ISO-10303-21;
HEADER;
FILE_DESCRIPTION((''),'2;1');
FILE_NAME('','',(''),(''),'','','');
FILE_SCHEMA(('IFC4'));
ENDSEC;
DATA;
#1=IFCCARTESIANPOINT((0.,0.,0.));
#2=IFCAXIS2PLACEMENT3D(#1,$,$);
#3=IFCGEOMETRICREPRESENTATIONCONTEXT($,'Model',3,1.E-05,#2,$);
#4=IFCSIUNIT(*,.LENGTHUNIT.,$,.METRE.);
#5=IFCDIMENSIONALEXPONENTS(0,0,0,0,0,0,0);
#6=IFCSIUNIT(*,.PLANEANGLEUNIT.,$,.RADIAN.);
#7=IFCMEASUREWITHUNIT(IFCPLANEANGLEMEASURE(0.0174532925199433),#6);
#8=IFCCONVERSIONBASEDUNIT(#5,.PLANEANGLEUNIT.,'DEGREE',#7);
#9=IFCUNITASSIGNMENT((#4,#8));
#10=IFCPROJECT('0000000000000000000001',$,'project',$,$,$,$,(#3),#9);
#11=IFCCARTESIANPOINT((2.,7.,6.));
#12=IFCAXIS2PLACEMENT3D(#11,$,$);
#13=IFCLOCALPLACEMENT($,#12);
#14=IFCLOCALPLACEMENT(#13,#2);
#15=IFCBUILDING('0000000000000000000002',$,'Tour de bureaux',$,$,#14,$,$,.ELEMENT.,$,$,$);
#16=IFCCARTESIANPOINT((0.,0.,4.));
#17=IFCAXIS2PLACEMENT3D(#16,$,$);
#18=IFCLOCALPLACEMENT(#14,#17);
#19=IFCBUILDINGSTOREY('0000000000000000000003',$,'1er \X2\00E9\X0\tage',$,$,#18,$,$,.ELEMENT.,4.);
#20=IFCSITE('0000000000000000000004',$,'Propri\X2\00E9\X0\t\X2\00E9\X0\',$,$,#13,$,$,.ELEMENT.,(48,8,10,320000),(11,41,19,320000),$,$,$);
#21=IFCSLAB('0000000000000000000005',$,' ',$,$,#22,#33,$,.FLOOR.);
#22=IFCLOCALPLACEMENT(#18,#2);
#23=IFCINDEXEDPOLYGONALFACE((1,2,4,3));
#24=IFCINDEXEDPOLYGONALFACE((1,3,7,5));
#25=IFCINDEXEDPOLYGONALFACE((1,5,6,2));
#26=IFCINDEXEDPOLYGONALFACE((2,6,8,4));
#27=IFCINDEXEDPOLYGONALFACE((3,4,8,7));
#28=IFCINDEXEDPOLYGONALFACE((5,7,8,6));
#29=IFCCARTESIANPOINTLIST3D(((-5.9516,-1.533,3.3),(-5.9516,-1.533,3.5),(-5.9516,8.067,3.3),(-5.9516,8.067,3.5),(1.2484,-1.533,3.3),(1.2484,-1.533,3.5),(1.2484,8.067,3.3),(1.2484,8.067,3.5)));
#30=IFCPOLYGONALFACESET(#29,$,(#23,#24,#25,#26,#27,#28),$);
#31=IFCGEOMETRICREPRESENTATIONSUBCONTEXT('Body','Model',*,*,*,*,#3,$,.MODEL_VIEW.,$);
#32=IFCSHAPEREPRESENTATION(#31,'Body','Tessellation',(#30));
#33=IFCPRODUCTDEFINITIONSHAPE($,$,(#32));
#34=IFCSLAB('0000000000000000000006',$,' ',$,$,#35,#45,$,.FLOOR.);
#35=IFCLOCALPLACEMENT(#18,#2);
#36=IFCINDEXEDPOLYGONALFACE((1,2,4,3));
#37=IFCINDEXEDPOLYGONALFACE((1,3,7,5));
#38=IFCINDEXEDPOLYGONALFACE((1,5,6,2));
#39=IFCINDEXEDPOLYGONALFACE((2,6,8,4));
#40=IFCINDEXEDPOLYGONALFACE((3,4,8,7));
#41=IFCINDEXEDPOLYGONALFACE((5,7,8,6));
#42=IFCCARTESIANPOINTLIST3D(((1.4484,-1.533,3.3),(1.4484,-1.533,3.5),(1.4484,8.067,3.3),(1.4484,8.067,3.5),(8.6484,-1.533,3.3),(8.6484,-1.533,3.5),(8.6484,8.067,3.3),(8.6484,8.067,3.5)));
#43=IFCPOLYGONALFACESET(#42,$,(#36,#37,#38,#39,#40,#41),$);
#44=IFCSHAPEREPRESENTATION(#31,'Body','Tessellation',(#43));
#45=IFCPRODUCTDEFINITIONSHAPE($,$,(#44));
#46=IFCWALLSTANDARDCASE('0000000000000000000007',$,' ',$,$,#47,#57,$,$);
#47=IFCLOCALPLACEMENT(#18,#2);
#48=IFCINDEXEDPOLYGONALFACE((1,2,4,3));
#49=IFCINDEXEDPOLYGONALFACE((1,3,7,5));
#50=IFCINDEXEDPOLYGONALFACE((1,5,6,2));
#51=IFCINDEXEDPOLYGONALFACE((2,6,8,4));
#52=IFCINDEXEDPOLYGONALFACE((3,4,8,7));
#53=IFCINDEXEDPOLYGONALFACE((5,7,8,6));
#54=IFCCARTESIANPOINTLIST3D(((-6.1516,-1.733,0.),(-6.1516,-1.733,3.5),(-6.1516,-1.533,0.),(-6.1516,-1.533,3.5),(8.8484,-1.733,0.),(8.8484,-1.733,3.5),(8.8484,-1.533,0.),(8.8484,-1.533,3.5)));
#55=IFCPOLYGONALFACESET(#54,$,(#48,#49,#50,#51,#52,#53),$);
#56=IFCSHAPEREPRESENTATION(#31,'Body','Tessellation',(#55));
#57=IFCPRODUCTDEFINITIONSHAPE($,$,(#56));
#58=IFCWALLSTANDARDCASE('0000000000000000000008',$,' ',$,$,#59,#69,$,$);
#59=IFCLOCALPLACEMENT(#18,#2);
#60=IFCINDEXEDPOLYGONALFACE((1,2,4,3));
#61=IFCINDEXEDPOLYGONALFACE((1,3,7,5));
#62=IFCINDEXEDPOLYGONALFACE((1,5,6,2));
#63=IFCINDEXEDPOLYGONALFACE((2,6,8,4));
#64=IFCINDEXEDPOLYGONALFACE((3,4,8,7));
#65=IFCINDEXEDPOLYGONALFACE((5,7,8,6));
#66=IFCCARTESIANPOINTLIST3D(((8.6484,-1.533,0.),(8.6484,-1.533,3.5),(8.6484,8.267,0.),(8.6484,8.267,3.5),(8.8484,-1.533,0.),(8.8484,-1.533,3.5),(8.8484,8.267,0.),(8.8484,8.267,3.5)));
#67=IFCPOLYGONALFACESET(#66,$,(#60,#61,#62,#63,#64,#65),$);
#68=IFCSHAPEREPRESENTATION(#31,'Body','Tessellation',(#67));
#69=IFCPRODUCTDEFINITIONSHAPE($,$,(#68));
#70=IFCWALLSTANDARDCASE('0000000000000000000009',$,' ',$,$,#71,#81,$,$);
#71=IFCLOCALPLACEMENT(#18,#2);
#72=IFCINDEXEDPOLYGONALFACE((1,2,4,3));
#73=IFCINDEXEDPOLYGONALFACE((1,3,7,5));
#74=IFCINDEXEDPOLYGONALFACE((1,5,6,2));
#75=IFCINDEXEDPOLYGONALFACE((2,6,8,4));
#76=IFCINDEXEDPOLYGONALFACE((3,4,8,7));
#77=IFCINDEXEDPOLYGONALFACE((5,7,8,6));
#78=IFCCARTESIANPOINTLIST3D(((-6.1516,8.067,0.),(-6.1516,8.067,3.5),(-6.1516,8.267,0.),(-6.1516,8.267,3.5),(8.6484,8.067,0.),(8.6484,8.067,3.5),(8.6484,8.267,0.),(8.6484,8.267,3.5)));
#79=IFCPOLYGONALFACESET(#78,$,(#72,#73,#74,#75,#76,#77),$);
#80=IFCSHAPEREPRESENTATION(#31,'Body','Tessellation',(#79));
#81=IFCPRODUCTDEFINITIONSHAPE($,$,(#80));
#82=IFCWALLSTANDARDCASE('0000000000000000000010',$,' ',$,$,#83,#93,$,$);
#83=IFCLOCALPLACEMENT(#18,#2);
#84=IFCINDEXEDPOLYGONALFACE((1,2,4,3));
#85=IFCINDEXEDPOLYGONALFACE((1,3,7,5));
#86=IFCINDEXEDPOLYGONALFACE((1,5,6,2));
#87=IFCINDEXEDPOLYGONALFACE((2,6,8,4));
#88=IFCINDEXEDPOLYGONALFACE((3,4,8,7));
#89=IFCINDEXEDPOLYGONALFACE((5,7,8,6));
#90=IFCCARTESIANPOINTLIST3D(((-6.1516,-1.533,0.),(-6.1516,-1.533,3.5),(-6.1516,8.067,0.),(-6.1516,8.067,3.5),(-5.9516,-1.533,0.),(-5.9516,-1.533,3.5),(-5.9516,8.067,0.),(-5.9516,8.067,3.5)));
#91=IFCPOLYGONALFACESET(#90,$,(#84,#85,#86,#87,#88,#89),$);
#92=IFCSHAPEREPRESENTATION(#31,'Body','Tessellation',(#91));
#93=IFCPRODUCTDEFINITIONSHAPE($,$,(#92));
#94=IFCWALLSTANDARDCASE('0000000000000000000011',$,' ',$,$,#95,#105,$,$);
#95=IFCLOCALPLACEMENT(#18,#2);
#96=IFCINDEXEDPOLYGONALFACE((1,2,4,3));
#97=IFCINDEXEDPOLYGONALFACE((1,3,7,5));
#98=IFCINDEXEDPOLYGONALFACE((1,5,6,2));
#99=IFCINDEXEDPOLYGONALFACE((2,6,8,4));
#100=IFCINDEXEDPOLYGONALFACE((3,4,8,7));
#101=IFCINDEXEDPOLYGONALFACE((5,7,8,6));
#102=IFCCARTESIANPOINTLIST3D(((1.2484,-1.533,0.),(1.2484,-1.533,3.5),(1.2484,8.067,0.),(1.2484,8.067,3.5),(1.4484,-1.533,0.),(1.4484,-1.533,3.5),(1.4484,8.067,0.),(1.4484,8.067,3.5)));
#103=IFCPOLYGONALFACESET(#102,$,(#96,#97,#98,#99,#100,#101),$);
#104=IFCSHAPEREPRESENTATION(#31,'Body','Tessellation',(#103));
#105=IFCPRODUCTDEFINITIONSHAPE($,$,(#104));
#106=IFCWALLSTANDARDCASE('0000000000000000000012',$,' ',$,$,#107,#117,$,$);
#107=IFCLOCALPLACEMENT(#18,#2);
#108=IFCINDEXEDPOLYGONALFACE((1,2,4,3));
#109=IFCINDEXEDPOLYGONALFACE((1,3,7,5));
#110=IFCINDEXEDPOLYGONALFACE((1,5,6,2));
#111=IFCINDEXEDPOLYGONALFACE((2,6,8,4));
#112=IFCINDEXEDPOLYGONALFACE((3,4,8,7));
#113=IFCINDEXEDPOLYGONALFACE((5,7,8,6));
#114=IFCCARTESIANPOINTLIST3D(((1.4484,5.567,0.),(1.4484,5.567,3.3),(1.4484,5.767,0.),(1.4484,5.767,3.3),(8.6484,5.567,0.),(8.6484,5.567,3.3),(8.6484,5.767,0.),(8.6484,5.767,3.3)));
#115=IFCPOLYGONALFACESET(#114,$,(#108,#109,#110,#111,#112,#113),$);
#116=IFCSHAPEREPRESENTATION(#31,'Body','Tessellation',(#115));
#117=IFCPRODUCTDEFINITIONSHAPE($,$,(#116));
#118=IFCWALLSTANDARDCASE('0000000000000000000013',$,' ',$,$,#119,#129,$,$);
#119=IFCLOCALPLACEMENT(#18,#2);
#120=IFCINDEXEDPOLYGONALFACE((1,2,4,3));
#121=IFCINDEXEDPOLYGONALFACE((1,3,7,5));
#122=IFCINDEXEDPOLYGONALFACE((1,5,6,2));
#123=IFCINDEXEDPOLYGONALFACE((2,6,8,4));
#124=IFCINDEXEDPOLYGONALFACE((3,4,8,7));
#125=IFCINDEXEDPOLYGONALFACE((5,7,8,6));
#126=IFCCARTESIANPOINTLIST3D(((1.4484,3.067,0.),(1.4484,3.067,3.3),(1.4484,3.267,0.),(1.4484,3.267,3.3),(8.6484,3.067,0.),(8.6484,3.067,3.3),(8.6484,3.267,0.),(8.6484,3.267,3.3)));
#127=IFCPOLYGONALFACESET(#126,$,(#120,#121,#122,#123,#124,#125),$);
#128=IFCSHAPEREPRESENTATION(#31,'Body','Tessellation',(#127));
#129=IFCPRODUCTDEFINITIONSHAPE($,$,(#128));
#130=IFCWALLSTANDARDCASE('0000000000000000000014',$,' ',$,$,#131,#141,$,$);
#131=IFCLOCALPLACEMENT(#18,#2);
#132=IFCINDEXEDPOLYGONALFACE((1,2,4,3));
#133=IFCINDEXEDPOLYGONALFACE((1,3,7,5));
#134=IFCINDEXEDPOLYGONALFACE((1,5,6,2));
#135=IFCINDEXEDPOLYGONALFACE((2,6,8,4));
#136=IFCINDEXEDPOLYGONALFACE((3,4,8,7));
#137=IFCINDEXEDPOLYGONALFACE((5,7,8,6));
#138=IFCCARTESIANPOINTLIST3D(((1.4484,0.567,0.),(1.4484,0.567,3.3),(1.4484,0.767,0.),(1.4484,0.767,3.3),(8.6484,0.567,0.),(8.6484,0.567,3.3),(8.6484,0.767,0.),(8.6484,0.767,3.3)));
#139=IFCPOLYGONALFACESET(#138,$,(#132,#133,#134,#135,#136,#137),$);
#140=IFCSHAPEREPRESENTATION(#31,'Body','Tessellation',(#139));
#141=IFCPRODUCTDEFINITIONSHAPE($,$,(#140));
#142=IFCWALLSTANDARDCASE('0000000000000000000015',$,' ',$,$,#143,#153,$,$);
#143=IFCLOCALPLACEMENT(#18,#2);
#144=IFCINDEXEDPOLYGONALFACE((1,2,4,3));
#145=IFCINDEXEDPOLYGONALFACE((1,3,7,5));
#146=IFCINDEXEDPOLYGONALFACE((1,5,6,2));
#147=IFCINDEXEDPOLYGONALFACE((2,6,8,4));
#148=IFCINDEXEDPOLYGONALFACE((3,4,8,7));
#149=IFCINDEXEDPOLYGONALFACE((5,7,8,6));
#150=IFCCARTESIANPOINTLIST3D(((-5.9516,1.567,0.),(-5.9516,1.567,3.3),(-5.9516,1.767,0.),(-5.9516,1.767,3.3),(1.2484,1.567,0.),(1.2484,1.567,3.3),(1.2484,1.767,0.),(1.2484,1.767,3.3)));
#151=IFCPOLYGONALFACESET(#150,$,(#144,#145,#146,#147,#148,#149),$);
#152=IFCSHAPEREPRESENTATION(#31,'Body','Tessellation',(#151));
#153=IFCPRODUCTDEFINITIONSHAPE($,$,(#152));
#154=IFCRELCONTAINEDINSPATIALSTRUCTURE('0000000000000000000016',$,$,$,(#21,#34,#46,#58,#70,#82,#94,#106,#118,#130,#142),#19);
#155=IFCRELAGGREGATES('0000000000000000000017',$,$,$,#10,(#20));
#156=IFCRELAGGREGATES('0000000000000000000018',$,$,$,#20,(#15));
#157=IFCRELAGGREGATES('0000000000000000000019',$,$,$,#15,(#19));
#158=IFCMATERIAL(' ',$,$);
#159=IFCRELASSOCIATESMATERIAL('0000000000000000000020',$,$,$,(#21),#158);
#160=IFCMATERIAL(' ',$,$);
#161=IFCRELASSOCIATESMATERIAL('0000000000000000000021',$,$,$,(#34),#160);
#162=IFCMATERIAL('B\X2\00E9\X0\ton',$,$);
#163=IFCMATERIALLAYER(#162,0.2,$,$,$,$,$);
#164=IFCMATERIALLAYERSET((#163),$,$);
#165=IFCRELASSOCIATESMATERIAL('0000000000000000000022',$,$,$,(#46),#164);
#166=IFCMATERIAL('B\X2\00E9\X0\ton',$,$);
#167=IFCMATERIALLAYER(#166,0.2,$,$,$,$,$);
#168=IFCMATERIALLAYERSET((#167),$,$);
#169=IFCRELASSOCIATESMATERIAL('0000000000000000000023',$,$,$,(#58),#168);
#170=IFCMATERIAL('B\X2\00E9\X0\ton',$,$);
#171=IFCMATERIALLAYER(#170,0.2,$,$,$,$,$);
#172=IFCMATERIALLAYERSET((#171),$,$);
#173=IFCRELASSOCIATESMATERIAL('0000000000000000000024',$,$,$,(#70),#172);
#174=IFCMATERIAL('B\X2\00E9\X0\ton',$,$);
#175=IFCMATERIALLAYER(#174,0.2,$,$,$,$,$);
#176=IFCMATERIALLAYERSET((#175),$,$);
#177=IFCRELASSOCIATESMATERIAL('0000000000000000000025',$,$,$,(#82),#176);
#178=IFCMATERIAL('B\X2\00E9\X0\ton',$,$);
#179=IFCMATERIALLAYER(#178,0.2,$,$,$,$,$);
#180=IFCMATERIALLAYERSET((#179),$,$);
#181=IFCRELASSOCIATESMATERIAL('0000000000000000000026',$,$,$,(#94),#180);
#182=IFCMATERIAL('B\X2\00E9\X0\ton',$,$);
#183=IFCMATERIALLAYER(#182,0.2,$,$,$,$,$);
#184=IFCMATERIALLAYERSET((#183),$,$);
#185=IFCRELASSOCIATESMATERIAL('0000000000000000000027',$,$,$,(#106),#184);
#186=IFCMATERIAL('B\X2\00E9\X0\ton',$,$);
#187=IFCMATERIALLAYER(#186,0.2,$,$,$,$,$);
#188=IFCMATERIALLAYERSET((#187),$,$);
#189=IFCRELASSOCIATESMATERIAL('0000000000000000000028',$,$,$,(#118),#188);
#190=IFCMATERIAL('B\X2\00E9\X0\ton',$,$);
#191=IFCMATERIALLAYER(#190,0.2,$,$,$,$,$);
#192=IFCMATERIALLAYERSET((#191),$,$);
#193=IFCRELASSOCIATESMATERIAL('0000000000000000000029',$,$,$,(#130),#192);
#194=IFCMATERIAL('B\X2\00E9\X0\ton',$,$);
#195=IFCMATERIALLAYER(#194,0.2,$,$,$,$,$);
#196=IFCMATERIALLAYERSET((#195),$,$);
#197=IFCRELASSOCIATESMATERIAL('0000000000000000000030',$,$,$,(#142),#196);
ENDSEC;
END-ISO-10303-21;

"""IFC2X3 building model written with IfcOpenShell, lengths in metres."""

from ifc_helpers import new_model, entity, si_unit, converted_unit, frame, frame_2d, origin, origin_with_axes, place, context, subcontext, project, spatial, rectangle, extrude, material, layer, layer_set, layer_usage, element, save


model = new_model("IFC2X3")

# Units and contexts
model_context = context("Model", 3, precision=1e-05, world=origin())
body_context = subcontext(model_context, "Body", "Model", "MODEL_VIEW")
ifc_project = project(units=[si_unit("LENGTHUNIT", "METRE"), converted_unit("PLANEANGLEUNIT", "DEGREE", entity("IfcPlaneAngleMeasure", 0.0174532925199433), si_unit("PLANEANGLEUNIT", "RADIAN"), dimensions=[0, 0, 0, 0, 0, 0, 0])], contexts=[model_context])

# Site, building, storey
site_placement = place(None, frame((2.0, 7.0, 6.0)))
site = spatial("IfcSite", under=ifc_project, at=site_placement, Name="Propriété", CompositionType="ELEMENT", RefLatitude=(48, 8, 10, 320000), RefLongitude=(11, 41, 19, 320000))
building_placement = place(site_placement, origin())
building = spatial("IfcBuilding", under=site, at=building_placement, Name="Tour de bureaux", CompositionType="ELEMENT")
storey_placement = place(building_placement, frame((0.0, 0.0, 4.0)))
storey = spatial("IfcBuildingStorey", under=building, at=storey_placement, Name="1er étage", CompositionType="ELEMENT", Elevation=4.0)

# Slabs
ifc_material_1 = material(Name=" ")
slab_1_placement = place(storey_placement, frame((-5.9516, -1.533, 3.3)))
element("IfcSlab", 1, at=slab_1_placement, inside=storey, material=ifc_material_1, Name=" ", PredefinedType="FLOOR", context=body_context, shape_type="SweptSolid", body=[
    extrude(rectangle(XDim=9.6, YDim=7.2, at=frame_2d((3.6, -4.8), x_axis=(0.0, -1.0))), frame((0.0, 9.6, 0.0), z_axis=(0.0, 0.0, 1.0), x_axis=(1.0, 0.0, 0.0)), (0.0, 0.0, 1.0), 0.2),
])
ifc_material_2 = material(Name=" ")
slab_2_placement = place(storey_placement, frame((1.4484, -1.533, 3.3)))
element("IfcSlab", 2, at=slab_2_placement, inside=storey, material=ifc_material_2, Name=" ", PredefinedType="FLOOR", context=body_context, shape_type="SweptSolid", body=[
    extrude(rectangle(XDim=9.6, YDim=7.2, at=frame_2d((3.6, -4.8), x_axis=(0.0, -1.0))), frame((0.0, 9.6, 0.0), z_axis=(0.0, 0.0, 1.0), x_axis=(1.0, 0.0, 0.0)), (0.0, 0.0, 1.0), 0.2),
])

# Walls
ifc_material_3 = material(Name="Béton")
ifc_layer_1 = layer(ifc_material_3, 0.2)
ifc_layer_set_1 = layer_set([ifc_layer_1])
ifc_layer_usage_1 = layer_usage(ifc_layer_set_1, "AXIS2", "POSITIVE", 0.0)
wall_1_placement = place(storey_placement, frame((-6.1516, -1.733, 0.0)))
element("IfcWallStandardCase", 3, at=wall_1_placement, inside=storey, material=ifc_layer_usage_1, Name=" ", context=body_context, shape_type="SweptSolid", body=[
    extrude(rectangle(XDim=15.0, YDim=0.2, at=frame_2d((7.5, 0.1), x_axis=(1.0, 0.0))), origin_with_axes(), (0.0, 0.0, 1.0), 3.5),
])
ifc_material_4 = material(Name="Béton")
ifc_layer_2 = layer(ifc_material_4, 0.2)
ifc_layer_set_2 = layer_set([ifc_layer_2])
ifc_layer_usage_2 = layer_usage(ifc_layer_set_2, "AXIS2", "POSITIVE", 0.0)
wall_2_placement = place(storey_placement, frame((8.8484, -1.533, 0.0), z_axis=(0.0, 0.0, 1.0), x_axis=(0.0, 1.0, 0.0)))
element("IfcWallStandardCase", 4, at=wall_2_placement, inside=storey, material=ifc_layer_usage_2, Name=" ", context=body_context, shape_type="SweptSolid", body=[
    extrude(rectangle(XDim=9.8, YDim=0.2, at=frame_2d((4.9, 0.1), x_axis=(1.0, 0.0))), origin_with_axes(), (0.0, 0.0, 1.0), 3.5),
])
ifc_material_5 = material(Name="Béton")
ifc_layer_3 = layer(ifc_material_5, 0.2)
ifc_layer_set_3 = layer_set([ifc_layer_3])
ifc_layer_usage_3 = layer_usage(ifc_layer_set_3, "AXIS2", "POSITIVE", 0.0)
wall_3_placement = place(storey_placement, frame((8.6484, 8.267, 0.0), z_axis=(0.0, 0.0, 1.0), x_axis=(-1.0, 0.0, 0.0)))
element("IfcWallStandardCase", 5, at=wall_3_placement, inside=storey, material=ifc_layer_usage_3, Name=" ", context=body_context, shape_type="SweptSolid", body=[
    extrude(rectangle(XDim=14.8, YDim=0.2, at=frame_2d((7.4, 0.1), x_axis=(1.0, 0.0))), origin_with_axes(), (0.0, 0.0, 1.0), 3.5),
])
ifc_material_6 = material(Name="Béton")
ifc_layer_4 = layer(ifc_material_6, 0.2)
ifc_layer_set_4 = layer_set([ifc_layer_4])
ifc_layer_usage_4 = layer_usage(ifc_layer_set_4, "AXIS2", "POSITIVE", 0.0)
wall_4_placement = place(storey_placement, frame((-6.1516, 8.067, 0.0), z_axis=(0.0, 0.0, 1.0), x_axis=(0.0, -1.0, 0.0)))
element("IfcWallStandardCase", 6, at=wall_4_placement, inside=storey, material=ifc_layer_usage_4, Name=" ", context=body_context, shape_type="SweptSolid", body=[
    extrude(rectangle(XDim=9.6, YDim=0.2, at=frame_2d((4.8, 0.1), x_axis=(1.0, 0.0))), origin_with_axes(), (0.0, 0.0, 1.0), 3.5),
])
ifc_material_7 = material(Name="Béton")
ifc_layer_5 = layer(ifc_material_7, 0.2)
ifc_layer_set_5 = layer_set([ifc_layer_5])
ifc_layer_usage_5 = layer_usage(ifc_layer_set_5, "AXIS2", "POSITIVE", -0.1)
wall_5_placement = place(storey_placement, frame((1.2484, 8.067, 0.0), z_axis=(0.0, 0.0, 1.0), x_axis=(0.0, -1.0, 0.0)))
element("IfcWallStandardCase", 7, at=wall_5_placement, inside=storey, material=ifc_layer_usage_5, Name=" ", context=body_context, shape_type="SweptSolid", body=[
    extrude(rectangle(XDim=9.6, YDim=0.2, at=frame_2d((4.8, 0.1), x_axis=(1.0, 0.0))), origin_with_axes(), (0.0, 0.0, 1.0), 3.5),
])
ifc_material_8 = material(Name="Béton")
ifc_layer_6 = layer(ifc_material_8, 0.2)
ifc_layer_set_6 = layer_set([ifc_layer_6])
ifc_layer_usage_6 = layer_usage(ifc_layer_set_6, "AXIS2", "POSITIVE", -0.1)
wall_6_placement = place(storey_placement, frame((1.4484, 5.567, 0.0), z_axis=(0.0, 0.0, 1.0), x_axis=(1.0, 0.0, 0.0)))
element("IfcWallStandardCase", 8, at=wall_6_placement, inside=storey, material=ifc_layer_usage_6, Name=" ", context=body_context, shape_type="SweptSolid", body=[
    extrude(rectangle(XDim=7.2, YDim=0.2, at=frame_2d((3.6, 0.1), x_axis=(1.0, 0.0))), origin_with_axes(), (0.0, 0.0, 1.0), 3.3),
])
ifc_material_9 = material(Name="Béton")
ifc_layer_7 = layer(ifc_material_9, 0.2)
ifc_layer_set_7 = layer_set([ifc_layer_7])
ifc_layer_usage_7 = layer_usage(ifc_layer_set_7, "AXIS2", "POSITIVE", -0.1)
wall_7_placement = place(storey_placement, frame((1.4484, 3.067, 0.0), z_axis=(0.0, 0.0, 1.0), x_axis=(1.0, 0.0, 0.0)))
element("IfcWallStandardCase", 9, at=wall_7_placement, inside=storey, material=ifc_layer_usage_7, Name=" ", context=body_context, shape_type="SweptSolid", body=[
    extrude(rectangle(XDim=7.2, YDim=0.2, at=frame_2d((3.6, 0.1), x_axis=(1.0, 0.0))), origin_with_axes(), (0.0, 0.0, 1.0), 3.3),
])
ifc_material_10 = material(Name="Béton")
ifc_layer_8 = layer(ifc_material_10, 0.2)
ifc_layer_set_8 = layer_set([ifc_layer_8])
ifc_layer_usage_8 = layer_usage(ifc_layer_set_8, "AXIS2", "POSITIVE", -0.1)
wall_8_placement = place(storey_placement, frame((1.4484, 0.567, 0.0), z_axis=(0.0, 0.0, 1.0), x_axis=(1.0, 0.0, 0.0)))
element("IfcWallStandardCase", 10, at=wall_8_placement, inside=storey, material=ifc_layer_usage_8, Name=" ", context=body_context, shape_type="SweptSolid", body=[
    extrude(rectangle(XDim=7.2, YDim=0.2, at=frame_2d((3.6, 0.1), x_axis=(1.0, 0.0))), origin_with_axes(), (0.0, 0.0, 1.0), 3.3),
])
ifc_material_11 = material(Name="Béton")
ifc_layer_9 = layer(ifc_material_11, 0.2)
ifc_layer_set_9 = layer_set([ifc_layer_9])
ifc_layer_usage_9 = layer_usage(ifc_layer_set_9, "AXIS2", "POSITIVE", -0.1)
wall_9_placement = place(storey_placement, frame((1.2484, 1.767, 0.0), z_axis=(0.0, 0.0, 1.0), x_axis=(-1.0, 0.0, 0.0)))
element("IfcWallStandardCase", 11, at=wall_9_placement, inside=storey, material=ifc_layer_usage_9, Name=" ", context=body_context, shape_type="SweptSolid", body=[
    extrude(rectangle(XDim=7.2, YDim=0.2, at=frame_2d((3.6, 0.1), x_axis=(1.0, 0.0))), origin_with_axes(), (0.0, 0.0, 1.0), 3.3),
])

save(model, "model.ifc")
